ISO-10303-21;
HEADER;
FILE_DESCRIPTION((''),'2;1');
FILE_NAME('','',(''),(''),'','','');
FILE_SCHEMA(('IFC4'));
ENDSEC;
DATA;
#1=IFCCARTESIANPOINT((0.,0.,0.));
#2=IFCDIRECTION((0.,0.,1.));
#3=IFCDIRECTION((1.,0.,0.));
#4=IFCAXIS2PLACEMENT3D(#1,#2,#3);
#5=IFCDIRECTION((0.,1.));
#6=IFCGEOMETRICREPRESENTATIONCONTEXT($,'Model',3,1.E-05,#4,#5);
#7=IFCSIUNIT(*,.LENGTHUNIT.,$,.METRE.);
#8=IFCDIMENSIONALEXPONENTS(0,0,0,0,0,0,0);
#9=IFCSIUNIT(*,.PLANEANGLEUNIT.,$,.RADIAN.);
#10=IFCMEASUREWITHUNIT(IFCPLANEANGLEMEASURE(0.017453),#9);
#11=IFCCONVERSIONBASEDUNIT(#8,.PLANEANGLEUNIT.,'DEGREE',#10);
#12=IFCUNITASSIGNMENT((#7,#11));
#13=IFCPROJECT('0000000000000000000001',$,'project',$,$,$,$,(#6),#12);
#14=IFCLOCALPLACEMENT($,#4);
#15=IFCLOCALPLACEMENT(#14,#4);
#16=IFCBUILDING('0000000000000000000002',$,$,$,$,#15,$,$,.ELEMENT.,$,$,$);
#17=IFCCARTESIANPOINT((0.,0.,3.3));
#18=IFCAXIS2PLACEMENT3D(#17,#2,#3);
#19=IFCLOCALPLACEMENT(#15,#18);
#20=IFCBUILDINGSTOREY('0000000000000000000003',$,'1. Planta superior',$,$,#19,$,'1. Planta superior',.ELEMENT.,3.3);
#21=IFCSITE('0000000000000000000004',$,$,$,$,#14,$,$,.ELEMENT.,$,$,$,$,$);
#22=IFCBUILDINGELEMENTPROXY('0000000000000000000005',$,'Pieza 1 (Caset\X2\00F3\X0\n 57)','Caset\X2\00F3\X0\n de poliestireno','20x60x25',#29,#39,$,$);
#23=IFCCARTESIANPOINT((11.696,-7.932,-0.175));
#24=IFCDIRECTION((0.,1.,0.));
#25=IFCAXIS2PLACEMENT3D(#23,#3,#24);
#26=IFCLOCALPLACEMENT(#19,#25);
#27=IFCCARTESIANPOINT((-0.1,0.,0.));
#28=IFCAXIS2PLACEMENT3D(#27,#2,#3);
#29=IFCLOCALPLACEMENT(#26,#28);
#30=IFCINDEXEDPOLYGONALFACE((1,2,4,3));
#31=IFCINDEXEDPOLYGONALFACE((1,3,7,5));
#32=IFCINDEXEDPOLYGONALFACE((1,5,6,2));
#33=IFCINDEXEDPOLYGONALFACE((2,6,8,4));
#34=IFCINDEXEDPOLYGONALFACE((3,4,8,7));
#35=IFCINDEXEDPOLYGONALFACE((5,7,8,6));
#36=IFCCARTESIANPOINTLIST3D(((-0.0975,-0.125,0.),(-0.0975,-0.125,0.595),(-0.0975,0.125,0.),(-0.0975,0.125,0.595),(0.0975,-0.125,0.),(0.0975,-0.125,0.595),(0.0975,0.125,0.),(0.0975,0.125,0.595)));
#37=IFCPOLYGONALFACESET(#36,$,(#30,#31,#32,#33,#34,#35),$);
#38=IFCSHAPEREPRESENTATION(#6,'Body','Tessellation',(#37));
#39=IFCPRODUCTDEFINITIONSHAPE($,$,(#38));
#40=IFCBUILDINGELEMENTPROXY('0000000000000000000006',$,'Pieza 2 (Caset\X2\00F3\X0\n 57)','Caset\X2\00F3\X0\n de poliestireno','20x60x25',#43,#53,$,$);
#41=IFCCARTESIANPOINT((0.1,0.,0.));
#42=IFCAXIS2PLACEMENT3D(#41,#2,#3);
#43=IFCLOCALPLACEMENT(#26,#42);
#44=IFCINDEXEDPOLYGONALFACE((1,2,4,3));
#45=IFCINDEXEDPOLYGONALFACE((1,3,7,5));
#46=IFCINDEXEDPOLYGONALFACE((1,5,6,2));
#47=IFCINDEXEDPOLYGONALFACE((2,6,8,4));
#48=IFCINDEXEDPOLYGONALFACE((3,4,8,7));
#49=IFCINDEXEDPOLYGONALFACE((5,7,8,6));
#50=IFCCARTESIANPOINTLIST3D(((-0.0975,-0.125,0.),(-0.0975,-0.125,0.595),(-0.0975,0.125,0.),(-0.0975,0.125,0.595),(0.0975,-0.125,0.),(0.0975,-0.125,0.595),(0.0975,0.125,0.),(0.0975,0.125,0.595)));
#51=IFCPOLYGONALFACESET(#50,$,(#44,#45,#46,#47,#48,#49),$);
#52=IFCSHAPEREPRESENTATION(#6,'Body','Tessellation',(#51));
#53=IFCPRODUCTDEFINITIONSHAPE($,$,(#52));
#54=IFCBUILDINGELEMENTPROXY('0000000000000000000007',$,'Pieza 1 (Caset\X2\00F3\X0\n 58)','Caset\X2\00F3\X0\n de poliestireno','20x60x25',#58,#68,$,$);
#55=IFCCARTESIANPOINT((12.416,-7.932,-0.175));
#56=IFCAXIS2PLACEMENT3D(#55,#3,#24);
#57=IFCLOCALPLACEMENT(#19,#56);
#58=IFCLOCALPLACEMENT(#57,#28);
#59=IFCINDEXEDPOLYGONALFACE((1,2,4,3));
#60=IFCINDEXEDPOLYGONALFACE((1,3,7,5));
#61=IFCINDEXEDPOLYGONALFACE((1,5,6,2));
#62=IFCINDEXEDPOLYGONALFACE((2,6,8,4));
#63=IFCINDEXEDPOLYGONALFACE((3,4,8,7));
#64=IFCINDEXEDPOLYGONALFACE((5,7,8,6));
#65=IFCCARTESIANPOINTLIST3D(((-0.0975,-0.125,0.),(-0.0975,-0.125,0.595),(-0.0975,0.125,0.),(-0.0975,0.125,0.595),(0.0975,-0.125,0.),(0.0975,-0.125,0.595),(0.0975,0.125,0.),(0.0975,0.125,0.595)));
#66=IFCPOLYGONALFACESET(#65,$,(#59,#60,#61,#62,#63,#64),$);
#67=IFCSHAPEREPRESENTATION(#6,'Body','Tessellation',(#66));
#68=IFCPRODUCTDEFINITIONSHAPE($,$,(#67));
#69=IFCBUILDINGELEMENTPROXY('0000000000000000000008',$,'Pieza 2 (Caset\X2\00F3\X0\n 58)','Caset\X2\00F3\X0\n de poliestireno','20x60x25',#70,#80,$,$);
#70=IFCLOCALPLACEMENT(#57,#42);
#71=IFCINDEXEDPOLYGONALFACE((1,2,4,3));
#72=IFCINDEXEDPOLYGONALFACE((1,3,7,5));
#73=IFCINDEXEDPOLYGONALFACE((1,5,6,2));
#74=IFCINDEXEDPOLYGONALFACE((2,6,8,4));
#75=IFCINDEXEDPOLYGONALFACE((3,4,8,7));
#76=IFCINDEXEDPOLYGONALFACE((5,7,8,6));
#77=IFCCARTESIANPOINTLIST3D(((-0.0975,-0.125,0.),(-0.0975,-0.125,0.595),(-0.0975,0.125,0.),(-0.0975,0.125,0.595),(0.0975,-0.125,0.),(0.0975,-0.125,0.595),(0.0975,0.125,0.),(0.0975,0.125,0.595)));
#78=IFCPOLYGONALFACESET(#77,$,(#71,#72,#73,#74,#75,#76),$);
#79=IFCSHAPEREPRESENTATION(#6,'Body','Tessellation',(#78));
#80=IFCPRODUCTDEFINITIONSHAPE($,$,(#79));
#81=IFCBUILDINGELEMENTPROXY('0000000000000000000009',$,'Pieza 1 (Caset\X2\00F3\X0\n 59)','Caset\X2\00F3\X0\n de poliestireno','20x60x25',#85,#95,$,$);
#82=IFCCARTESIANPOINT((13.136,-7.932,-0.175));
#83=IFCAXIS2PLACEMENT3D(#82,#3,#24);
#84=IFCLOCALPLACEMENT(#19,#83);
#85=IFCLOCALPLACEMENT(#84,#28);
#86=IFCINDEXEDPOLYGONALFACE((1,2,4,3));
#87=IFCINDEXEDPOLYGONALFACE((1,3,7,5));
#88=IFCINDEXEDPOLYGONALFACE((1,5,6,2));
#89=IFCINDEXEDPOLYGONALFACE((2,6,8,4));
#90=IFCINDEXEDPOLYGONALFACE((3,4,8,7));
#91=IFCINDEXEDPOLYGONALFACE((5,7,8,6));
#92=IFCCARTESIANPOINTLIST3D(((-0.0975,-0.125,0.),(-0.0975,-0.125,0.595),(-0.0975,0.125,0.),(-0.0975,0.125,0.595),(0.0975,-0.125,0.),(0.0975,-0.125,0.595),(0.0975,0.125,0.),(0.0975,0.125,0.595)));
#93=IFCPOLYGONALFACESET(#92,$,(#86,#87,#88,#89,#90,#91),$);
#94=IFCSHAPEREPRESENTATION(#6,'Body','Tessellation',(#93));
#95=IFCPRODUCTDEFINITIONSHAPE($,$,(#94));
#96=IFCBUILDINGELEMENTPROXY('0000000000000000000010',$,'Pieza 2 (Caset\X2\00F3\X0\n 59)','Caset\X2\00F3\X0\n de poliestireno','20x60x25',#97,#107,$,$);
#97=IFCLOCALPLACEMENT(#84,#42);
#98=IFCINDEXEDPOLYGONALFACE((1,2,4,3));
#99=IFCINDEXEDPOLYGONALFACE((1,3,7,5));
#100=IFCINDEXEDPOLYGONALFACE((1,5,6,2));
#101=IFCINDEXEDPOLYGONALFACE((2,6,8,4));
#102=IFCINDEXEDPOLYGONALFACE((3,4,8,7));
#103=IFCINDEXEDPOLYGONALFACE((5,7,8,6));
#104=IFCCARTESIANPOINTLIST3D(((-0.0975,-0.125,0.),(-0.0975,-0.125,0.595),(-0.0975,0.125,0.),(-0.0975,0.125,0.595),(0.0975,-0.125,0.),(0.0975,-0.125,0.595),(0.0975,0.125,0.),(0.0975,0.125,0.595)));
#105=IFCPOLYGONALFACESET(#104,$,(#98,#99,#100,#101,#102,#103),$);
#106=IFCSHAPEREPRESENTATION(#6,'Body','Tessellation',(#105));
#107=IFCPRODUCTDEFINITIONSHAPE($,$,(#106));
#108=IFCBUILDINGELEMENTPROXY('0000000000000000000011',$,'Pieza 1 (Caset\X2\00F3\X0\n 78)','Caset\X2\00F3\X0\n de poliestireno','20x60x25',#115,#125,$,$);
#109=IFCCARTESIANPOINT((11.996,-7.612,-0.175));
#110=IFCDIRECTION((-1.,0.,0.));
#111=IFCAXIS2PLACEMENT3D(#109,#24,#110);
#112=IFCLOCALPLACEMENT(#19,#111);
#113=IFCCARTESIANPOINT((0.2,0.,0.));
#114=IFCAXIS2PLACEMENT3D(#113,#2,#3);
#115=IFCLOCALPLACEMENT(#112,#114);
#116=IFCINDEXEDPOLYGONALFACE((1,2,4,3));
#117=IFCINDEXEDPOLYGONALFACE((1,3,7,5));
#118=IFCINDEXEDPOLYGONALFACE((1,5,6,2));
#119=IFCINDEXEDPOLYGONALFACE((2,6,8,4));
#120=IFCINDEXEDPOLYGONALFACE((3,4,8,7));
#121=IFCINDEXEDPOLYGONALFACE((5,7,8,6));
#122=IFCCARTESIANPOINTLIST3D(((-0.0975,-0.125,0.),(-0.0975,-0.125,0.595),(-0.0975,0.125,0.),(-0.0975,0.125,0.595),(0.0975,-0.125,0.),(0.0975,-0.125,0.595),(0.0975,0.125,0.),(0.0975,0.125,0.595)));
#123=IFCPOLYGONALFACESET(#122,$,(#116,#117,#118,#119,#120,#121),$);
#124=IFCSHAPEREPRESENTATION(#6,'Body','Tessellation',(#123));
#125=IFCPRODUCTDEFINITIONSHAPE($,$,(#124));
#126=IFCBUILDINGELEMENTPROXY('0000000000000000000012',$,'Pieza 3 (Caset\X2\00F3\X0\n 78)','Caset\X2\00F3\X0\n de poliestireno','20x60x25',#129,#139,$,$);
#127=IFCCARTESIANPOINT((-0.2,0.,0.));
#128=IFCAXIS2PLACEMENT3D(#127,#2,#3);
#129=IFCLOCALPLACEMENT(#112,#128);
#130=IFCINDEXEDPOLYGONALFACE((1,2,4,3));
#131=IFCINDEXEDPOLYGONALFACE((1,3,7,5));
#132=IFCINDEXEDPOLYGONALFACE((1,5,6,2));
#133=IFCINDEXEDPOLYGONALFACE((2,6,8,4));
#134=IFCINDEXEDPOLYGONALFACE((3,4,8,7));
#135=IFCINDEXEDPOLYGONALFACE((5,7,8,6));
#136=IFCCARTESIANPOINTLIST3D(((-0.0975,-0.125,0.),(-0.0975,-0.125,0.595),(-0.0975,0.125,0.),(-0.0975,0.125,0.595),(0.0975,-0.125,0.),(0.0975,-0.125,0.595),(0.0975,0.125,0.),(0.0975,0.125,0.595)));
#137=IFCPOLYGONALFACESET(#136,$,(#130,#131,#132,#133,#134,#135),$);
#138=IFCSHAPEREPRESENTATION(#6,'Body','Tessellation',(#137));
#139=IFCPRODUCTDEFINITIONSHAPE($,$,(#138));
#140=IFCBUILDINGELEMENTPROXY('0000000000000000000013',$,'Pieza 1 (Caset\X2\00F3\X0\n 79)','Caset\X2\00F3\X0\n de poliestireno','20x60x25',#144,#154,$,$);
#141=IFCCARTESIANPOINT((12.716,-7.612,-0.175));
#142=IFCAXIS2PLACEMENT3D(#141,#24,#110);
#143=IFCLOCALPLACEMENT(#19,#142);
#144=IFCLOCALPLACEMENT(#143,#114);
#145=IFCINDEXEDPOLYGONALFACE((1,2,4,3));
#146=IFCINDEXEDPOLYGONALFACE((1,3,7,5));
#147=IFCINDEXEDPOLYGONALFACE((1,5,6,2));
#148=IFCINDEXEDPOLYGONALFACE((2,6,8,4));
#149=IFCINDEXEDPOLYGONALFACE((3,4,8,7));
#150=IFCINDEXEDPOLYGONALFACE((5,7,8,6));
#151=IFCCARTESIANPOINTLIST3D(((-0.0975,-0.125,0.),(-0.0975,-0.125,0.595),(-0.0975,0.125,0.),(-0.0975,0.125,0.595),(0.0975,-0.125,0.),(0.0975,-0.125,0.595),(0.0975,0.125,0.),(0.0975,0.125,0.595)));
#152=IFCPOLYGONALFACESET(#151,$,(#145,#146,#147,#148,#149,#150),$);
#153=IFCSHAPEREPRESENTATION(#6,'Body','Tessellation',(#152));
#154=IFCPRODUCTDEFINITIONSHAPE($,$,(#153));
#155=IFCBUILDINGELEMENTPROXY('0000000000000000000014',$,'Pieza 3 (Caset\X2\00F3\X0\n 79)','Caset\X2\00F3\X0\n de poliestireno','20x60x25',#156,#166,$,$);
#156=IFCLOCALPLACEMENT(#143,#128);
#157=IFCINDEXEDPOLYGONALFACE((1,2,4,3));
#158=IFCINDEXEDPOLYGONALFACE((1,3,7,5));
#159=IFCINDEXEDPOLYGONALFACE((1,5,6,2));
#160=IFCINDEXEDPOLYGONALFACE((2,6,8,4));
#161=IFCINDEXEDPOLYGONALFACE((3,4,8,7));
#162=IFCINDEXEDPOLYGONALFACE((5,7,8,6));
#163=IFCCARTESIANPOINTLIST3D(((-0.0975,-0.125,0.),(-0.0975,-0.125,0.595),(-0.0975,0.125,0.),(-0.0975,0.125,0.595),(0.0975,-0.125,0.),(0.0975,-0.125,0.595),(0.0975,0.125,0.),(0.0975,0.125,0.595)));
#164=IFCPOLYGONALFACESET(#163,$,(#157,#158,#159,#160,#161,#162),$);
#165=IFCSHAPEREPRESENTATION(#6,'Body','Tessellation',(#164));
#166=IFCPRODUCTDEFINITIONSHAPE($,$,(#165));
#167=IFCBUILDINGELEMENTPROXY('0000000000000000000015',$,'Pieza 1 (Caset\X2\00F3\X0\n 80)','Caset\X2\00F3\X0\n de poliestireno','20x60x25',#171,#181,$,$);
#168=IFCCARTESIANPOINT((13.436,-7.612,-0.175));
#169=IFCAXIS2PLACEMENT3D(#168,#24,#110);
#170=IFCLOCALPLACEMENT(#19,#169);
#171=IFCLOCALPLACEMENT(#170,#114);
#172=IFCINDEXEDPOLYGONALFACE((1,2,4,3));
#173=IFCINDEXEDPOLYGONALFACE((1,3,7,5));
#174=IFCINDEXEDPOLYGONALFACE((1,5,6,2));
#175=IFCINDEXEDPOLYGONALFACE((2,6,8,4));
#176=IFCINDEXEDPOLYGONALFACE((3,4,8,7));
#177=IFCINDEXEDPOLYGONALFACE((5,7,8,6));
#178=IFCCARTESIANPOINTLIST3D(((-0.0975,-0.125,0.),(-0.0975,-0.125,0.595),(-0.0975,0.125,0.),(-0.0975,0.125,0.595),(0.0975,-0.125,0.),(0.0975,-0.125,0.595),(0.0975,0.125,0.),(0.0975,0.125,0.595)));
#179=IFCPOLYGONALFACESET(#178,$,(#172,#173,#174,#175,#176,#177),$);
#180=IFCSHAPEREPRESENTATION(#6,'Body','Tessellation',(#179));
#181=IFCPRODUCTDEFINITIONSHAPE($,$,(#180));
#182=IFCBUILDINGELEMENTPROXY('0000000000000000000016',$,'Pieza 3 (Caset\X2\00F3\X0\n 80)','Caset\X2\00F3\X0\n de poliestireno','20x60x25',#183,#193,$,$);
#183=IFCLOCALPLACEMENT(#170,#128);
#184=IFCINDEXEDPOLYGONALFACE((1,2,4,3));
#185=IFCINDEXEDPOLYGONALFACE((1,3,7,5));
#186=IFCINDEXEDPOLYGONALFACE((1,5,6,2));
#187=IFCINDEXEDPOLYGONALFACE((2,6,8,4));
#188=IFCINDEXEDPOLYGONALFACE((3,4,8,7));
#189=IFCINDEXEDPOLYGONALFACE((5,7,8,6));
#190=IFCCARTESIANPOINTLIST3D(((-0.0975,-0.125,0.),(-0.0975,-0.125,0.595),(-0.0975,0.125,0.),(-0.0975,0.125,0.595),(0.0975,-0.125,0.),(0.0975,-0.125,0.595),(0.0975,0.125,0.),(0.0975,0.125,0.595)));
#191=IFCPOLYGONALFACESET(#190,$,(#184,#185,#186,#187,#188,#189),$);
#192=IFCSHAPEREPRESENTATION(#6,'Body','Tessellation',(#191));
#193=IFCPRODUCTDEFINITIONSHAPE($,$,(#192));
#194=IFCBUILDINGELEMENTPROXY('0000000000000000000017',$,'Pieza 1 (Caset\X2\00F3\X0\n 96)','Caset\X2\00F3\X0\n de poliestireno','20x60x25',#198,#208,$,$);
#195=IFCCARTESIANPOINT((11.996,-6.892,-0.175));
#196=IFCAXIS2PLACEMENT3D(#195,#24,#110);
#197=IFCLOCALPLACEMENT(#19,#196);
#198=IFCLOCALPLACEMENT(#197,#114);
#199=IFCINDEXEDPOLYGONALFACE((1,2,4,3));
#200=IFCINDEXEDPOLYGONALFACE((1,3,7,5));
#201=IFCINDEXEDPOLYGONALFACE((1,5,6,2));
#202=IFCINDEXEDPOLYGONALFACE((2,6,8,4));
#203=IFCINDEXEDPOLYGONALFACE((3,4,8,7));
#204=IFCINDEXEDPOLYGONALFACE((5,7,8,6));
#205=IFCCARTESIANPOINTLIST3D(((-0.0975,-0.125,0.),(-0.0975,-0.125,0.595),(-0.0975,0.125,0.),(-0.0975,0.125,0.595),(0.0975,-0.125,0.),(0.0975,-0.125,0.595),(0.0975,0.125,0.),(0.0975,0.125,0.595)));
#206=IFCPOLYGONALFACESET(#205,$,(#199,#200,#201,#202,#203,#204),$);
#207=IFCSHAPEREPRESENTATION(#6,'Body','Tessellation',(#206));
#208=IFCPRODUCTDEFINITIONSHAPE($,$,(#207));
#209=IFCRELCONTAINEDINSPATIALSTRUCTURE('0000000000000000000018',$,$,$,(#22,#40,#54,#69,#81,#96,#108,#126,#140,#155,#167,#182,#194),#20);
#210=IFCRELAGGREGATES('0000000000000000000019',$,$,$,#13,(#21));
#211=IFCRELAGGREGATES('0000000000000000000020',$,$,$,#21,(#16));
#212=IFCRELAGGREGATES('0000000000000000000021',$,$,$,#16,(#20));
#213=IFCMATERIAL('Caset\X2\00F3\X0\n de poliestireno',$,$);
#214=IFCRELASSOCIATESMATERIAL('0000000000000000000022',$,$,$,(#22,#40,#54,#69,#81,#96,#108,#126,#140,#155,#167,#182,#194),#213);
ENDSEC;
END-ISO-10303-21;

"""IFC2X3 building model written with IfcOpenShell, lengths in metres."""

from ifc_helpers import new_model, entity, si_unit, converted_unit, direction, frame, origin_with_axes, origin_2d_with_axis, place, context, project, spatial, rectangle, extrude, source, transform, mapped, material, element, save


model = new_model("IFC2X3")

# Units and contexts
model_context = context("Model", 3, precision=1e-05, world=origin_with_axes(), true_north=direction((0.0, 1.0)))
ifc_project = project(units=[si_unit("LENGTHUNIT", "METRE"), converted_unit("PLANEANGLEUNIT", "DEGREE", entity("IfcPlaneAngleMeasure", 0.017453), si_unit("PLANEANGLEUNIT", "RADIAN"), dimensions=[0, 0, 0, 0, 0, 0, 0])], contexts=[model_context])

# Site, building, storey
site_placement = place(None, origin_with_axes())
site = spatial("IfcSite", under=ifc_project, at=site_placement, CompositionType="ELEMENT")
building_placement = place(site_placement, origin_with_axes())
building = spatial("IfcBuilding", under=site, at=building_placement, CompositionType="ELEMENT")
storey_placement = place(building_placement, frame((0.0, 0.0, 3.3), z_axis=(0.0, 0.0, 1.0), x_axis=(1.0, 0.0, 0.0)))
storey = spatial("IfcBuildingStorey", under=building, at=storey_placement, Name="1. Planta superior", LongName="1. Planta superior", CompositionType="ELEMENT", Elevation=3.3)

# Building element proxies
ifc_material_1 = material(Name="Casetón de poliestireno")
shared_shape = source(origin_with_axes(), model_context, "Body", "SweptSolid", [
    extrude(rectangle(XDim=0.195, YDim=0.25, at=origin_2d_with_axis()), origin_with_axes(), (0.0, 0.0, 1.0), 0.595),
])
placement_1 = place(storey_placement, frame((11.696, -7.932, -0.175), z_axis=(1.0, 0.0, 0.0), x_axis=(0.0, 1.0, 0.0)))
for number, where, z_axis, x_axis, name in (
    (1, (-0.1, 0.0, 0.0), (0.0, 0.0, 1.0), (1.0, 0.0, 0.0), "Pieza 1 (Casetón 57)"),
    (2, (0.1, 0.0, 0.0), (0.0, 0.0, 1.0), (1.0, 0.0, 0.0), "Pieza 2 (Casetón 57)"),
):
    element("IfcBuildingElementProxy", number, at=place(placement_1, frame(where, z_axis=z_axis, x_axis=x_axis)), inside=storey, material=ifc_material_1, Name=name, Description="Casetón de poliestireno", ObjectType="20x60x25", context=model_context, shape_type="MappedRepresentation", body=[
        mapped(shared_shape, transform((0.0, 0.0, 0.0), x_axis=(1.0, 0.0, 0.0), y_axis=(0.0, 1.0, 0.0), z_axis=(0.0, 0.0, 1.0))),
    ])
placement_2 = place(storey_placement, frame((12.416, -7.932, -0.175), z_axis=(1.0, 0.0, 0.0), x_axis=(0.0, 1.0, 0.0)))
for number, where, z_axis, x_axis, name in (
    (3, (-0.1, 0.0, 0.0), (0.0, 0.0, 1.0), (1.0, 0.0, 0.0), "Pieza 1 (Casetón 58)"),
    (4, (0.1, 0.0, 0.0), (0.0, 0.0, 1.0), (1.0, 0.0, 0.0), "Pieza 2 (Casetón 58)"),
):
    element("IfcBuildingElementProxy", number, at=place(placement_2, frame(where, z_axis=z_axis, x_axis=x_axis)), inside=storey, material=ifc_material_1, Name=name, Description="Casetón de poliestireno", ObjectType="20x60x25", context=model_context, shape_type="MappedRepresentation", body=[
        mapped(shared_shape, transform((0.0, 0.0, 0.0), x_axis=(1.0, 0.0, 0.0), y_axis=(0.0, 1.0, 0.0), z_axis=(0.0, 0.0, 1.0))),
    ])
placement_3 = place(storey_placement, frame((13.136, -7.932, -0.175), z_axis=(1.0, 0.0, 0.0), x_axis=(0.0, 1.0, 0.0)))
for number, where, z_axis, x_axis, name in (
    (5, (-0.1, 0.0, 0.0), (0.0, 0.0, 1.0), (1.0, 0.0, 0.0), "Pieza 1 (Casetón 59)"),
    (6, (0.1, 0.0, 0.0), (0.0, 0.0, 1.0), (1.0, 0.0, 0.0), "Pieza 2 (Casetón 59)"),
):
    element("IfcBuildingElementProxy", number, at=place(placement_3, frame(where, z_axis=z_axis, x_axis=x_axis)), inside=storey, material=ifc_material_1, Name=name, Description="Casetón de poliestireno", ObjectType="20x60x25", context=model_context, shape_type="MappedRepresentation", body=[
        mapped(shared_shape, transform((0.0, 0.0, 0.0), x_axis=(1.0, 0.0, 0.0), y_axis=(0.0, 1.0, 0.0), z_axis=(0.0, 0.0, 1.0))),
    ])
placement_4 = place(storey_placement, frame((11.996, -7.612, -0.175), z_axis=(0.0, 1.0, 0.0), x_axis=(-1.0, 0.0, 0.0)))
for number, where, z_axis, x_axis, name in (
    (7, (0.2, 0.0, 0.0), (0.0, 0.0, 1.0), (1.0, 0.0, 0.0), "Pieza 1 (Casetón 78)"),
    (8, (-0.2, 0.0, 0.0), (0.0, 0.0, 1.0), (1.0, 0.0, 0.0), "Pieza 3 (Casetón 78)"),
):
    element("IfcBuildingElementProxy", number, at=place(placement_4, frame(where, z_axis=z_axis, x_axis=x_axis)), inside=storey, material=ifc_material_1, Name=name, Description="Casetón de poliestireno", ObjectType="20x60x25", context=model_context, shape_type="MappedRepresentation", body=[
        mapped(shared_shape, transform((0.0, 0.0, 0.0), x_axis=(1.0, 0.0, 0.0), y_axis=(0.0, 1.0, 0.0), z_axis=(0.0, 0.0, 1.0))),
    ])
placement_5 = place(storey_placement, frame((12.716, -7.612, -0.175), z_axis=(0.0, 1.0, 0.0), x_axis=(-1.0, 0.0, 0.0)))
for number, where, z_axis, x_axis, name in (
    (9, (0.2, 0.0, 0.0), (0.0, 0.0, 1.0), (1.0, 0.0, 0.0), "Pieza 1 (Casetón 79)"),
    (10, (-0.2, 0.0, 0.0), (0.0, 0.0, 1.0), (1.0, 0.0, 0.0), "Pieza 3 (Casetón 79)"),
):
    element("IfcBuildingElementProxy", number, at=place(placement_5, frame(where, z_axis=z_axis, x_axis=x_axis)), inside=storey, material=ifc_material_1, Name=name, Description="Casetón de poliestireno", ObjectType="20x60x25", context=model_context, shape_type="MappedRepresentation", body=[
        mapped(shared_shape, transform((0.0, 0.0, 0.0), x_axis=(1.0, 0.0, 0.0), y_axis=(0.0, 1.0, 0.0), z_axis=(0.0, 0.0, 1.0))),
    ])
placement_6 = place(storey_placement, frame((13.436, -7.612, -0.175), z_axis=(0.0, 1.0, 0.0), x_axis=(-1.0, 0.0, 0.0)))
for number, where, z_axis, x_axis, name in (
    (11, (0.2, 0.0, 0.0), (0.0, 0.0, 1.0), (1.0, 0.0, 0.0), "Pieza 1 (Casetón 80)"),
    (12, (-0.2, 0.0, 0.0), (0.0, 0.0, 1.0), (1.0, 0.0, 0.0), "Pieza 3 (Casetón 80)"),
):
    element("IfcBuildingElementProxy", number, at=place(placement_6, frame(where, z_axis=z_axis, x_axis=x_axis)), inside=storey, material=ifc_material_1, Name=name, Description="Casetón de poliestireno", ObjectType="20x60x25", context=model_context, shape_type="MappedRepresentation", body=[
        mapped(shared_shape, transform((0.0, 0.0, 0.0), x_axis=(1.0, 0.0, 0.0), y_axis=(0.0, 1.0, 0.0), z_axis=(0.0, 0.0, 1.0))),
    ])
placement_7 = place(storey_placement, frame((11.996, -6.892, -0.175), z_axis=(0.0, 1.0, 0.0), x_axis=(-1.0, 0.0, 0.0)))
for number, where, z_axis, x_axis, name in (
    (13, (0.2, 0.0, 0.0), (0.0, 0.0, 1.0), (1.0, 0.0, 0.0), "Pieza 1 (Casetón 96)"),
):
    element("IfcBuildingElementProxy", number, at=place(placement_7, frame(where, z_axis=z_axis, x_axis=x_axis)), inside=storey, material=ifc_material_1, Name=name, Description="Casetón de poliestireno", ObjectType="20x60x25", context=model_context, shape_type="MappedRepresentation", body=[
        mapped(shared_shape, transform((0.0, 0.0, 0.0), x_axis=(1.0, 0.0, 0.0), y_axis=(0.0, 1.0, 0.0), z_axis=(0.0, 0.0, 1.0))),
    ])

save(model, "model.ifc")
